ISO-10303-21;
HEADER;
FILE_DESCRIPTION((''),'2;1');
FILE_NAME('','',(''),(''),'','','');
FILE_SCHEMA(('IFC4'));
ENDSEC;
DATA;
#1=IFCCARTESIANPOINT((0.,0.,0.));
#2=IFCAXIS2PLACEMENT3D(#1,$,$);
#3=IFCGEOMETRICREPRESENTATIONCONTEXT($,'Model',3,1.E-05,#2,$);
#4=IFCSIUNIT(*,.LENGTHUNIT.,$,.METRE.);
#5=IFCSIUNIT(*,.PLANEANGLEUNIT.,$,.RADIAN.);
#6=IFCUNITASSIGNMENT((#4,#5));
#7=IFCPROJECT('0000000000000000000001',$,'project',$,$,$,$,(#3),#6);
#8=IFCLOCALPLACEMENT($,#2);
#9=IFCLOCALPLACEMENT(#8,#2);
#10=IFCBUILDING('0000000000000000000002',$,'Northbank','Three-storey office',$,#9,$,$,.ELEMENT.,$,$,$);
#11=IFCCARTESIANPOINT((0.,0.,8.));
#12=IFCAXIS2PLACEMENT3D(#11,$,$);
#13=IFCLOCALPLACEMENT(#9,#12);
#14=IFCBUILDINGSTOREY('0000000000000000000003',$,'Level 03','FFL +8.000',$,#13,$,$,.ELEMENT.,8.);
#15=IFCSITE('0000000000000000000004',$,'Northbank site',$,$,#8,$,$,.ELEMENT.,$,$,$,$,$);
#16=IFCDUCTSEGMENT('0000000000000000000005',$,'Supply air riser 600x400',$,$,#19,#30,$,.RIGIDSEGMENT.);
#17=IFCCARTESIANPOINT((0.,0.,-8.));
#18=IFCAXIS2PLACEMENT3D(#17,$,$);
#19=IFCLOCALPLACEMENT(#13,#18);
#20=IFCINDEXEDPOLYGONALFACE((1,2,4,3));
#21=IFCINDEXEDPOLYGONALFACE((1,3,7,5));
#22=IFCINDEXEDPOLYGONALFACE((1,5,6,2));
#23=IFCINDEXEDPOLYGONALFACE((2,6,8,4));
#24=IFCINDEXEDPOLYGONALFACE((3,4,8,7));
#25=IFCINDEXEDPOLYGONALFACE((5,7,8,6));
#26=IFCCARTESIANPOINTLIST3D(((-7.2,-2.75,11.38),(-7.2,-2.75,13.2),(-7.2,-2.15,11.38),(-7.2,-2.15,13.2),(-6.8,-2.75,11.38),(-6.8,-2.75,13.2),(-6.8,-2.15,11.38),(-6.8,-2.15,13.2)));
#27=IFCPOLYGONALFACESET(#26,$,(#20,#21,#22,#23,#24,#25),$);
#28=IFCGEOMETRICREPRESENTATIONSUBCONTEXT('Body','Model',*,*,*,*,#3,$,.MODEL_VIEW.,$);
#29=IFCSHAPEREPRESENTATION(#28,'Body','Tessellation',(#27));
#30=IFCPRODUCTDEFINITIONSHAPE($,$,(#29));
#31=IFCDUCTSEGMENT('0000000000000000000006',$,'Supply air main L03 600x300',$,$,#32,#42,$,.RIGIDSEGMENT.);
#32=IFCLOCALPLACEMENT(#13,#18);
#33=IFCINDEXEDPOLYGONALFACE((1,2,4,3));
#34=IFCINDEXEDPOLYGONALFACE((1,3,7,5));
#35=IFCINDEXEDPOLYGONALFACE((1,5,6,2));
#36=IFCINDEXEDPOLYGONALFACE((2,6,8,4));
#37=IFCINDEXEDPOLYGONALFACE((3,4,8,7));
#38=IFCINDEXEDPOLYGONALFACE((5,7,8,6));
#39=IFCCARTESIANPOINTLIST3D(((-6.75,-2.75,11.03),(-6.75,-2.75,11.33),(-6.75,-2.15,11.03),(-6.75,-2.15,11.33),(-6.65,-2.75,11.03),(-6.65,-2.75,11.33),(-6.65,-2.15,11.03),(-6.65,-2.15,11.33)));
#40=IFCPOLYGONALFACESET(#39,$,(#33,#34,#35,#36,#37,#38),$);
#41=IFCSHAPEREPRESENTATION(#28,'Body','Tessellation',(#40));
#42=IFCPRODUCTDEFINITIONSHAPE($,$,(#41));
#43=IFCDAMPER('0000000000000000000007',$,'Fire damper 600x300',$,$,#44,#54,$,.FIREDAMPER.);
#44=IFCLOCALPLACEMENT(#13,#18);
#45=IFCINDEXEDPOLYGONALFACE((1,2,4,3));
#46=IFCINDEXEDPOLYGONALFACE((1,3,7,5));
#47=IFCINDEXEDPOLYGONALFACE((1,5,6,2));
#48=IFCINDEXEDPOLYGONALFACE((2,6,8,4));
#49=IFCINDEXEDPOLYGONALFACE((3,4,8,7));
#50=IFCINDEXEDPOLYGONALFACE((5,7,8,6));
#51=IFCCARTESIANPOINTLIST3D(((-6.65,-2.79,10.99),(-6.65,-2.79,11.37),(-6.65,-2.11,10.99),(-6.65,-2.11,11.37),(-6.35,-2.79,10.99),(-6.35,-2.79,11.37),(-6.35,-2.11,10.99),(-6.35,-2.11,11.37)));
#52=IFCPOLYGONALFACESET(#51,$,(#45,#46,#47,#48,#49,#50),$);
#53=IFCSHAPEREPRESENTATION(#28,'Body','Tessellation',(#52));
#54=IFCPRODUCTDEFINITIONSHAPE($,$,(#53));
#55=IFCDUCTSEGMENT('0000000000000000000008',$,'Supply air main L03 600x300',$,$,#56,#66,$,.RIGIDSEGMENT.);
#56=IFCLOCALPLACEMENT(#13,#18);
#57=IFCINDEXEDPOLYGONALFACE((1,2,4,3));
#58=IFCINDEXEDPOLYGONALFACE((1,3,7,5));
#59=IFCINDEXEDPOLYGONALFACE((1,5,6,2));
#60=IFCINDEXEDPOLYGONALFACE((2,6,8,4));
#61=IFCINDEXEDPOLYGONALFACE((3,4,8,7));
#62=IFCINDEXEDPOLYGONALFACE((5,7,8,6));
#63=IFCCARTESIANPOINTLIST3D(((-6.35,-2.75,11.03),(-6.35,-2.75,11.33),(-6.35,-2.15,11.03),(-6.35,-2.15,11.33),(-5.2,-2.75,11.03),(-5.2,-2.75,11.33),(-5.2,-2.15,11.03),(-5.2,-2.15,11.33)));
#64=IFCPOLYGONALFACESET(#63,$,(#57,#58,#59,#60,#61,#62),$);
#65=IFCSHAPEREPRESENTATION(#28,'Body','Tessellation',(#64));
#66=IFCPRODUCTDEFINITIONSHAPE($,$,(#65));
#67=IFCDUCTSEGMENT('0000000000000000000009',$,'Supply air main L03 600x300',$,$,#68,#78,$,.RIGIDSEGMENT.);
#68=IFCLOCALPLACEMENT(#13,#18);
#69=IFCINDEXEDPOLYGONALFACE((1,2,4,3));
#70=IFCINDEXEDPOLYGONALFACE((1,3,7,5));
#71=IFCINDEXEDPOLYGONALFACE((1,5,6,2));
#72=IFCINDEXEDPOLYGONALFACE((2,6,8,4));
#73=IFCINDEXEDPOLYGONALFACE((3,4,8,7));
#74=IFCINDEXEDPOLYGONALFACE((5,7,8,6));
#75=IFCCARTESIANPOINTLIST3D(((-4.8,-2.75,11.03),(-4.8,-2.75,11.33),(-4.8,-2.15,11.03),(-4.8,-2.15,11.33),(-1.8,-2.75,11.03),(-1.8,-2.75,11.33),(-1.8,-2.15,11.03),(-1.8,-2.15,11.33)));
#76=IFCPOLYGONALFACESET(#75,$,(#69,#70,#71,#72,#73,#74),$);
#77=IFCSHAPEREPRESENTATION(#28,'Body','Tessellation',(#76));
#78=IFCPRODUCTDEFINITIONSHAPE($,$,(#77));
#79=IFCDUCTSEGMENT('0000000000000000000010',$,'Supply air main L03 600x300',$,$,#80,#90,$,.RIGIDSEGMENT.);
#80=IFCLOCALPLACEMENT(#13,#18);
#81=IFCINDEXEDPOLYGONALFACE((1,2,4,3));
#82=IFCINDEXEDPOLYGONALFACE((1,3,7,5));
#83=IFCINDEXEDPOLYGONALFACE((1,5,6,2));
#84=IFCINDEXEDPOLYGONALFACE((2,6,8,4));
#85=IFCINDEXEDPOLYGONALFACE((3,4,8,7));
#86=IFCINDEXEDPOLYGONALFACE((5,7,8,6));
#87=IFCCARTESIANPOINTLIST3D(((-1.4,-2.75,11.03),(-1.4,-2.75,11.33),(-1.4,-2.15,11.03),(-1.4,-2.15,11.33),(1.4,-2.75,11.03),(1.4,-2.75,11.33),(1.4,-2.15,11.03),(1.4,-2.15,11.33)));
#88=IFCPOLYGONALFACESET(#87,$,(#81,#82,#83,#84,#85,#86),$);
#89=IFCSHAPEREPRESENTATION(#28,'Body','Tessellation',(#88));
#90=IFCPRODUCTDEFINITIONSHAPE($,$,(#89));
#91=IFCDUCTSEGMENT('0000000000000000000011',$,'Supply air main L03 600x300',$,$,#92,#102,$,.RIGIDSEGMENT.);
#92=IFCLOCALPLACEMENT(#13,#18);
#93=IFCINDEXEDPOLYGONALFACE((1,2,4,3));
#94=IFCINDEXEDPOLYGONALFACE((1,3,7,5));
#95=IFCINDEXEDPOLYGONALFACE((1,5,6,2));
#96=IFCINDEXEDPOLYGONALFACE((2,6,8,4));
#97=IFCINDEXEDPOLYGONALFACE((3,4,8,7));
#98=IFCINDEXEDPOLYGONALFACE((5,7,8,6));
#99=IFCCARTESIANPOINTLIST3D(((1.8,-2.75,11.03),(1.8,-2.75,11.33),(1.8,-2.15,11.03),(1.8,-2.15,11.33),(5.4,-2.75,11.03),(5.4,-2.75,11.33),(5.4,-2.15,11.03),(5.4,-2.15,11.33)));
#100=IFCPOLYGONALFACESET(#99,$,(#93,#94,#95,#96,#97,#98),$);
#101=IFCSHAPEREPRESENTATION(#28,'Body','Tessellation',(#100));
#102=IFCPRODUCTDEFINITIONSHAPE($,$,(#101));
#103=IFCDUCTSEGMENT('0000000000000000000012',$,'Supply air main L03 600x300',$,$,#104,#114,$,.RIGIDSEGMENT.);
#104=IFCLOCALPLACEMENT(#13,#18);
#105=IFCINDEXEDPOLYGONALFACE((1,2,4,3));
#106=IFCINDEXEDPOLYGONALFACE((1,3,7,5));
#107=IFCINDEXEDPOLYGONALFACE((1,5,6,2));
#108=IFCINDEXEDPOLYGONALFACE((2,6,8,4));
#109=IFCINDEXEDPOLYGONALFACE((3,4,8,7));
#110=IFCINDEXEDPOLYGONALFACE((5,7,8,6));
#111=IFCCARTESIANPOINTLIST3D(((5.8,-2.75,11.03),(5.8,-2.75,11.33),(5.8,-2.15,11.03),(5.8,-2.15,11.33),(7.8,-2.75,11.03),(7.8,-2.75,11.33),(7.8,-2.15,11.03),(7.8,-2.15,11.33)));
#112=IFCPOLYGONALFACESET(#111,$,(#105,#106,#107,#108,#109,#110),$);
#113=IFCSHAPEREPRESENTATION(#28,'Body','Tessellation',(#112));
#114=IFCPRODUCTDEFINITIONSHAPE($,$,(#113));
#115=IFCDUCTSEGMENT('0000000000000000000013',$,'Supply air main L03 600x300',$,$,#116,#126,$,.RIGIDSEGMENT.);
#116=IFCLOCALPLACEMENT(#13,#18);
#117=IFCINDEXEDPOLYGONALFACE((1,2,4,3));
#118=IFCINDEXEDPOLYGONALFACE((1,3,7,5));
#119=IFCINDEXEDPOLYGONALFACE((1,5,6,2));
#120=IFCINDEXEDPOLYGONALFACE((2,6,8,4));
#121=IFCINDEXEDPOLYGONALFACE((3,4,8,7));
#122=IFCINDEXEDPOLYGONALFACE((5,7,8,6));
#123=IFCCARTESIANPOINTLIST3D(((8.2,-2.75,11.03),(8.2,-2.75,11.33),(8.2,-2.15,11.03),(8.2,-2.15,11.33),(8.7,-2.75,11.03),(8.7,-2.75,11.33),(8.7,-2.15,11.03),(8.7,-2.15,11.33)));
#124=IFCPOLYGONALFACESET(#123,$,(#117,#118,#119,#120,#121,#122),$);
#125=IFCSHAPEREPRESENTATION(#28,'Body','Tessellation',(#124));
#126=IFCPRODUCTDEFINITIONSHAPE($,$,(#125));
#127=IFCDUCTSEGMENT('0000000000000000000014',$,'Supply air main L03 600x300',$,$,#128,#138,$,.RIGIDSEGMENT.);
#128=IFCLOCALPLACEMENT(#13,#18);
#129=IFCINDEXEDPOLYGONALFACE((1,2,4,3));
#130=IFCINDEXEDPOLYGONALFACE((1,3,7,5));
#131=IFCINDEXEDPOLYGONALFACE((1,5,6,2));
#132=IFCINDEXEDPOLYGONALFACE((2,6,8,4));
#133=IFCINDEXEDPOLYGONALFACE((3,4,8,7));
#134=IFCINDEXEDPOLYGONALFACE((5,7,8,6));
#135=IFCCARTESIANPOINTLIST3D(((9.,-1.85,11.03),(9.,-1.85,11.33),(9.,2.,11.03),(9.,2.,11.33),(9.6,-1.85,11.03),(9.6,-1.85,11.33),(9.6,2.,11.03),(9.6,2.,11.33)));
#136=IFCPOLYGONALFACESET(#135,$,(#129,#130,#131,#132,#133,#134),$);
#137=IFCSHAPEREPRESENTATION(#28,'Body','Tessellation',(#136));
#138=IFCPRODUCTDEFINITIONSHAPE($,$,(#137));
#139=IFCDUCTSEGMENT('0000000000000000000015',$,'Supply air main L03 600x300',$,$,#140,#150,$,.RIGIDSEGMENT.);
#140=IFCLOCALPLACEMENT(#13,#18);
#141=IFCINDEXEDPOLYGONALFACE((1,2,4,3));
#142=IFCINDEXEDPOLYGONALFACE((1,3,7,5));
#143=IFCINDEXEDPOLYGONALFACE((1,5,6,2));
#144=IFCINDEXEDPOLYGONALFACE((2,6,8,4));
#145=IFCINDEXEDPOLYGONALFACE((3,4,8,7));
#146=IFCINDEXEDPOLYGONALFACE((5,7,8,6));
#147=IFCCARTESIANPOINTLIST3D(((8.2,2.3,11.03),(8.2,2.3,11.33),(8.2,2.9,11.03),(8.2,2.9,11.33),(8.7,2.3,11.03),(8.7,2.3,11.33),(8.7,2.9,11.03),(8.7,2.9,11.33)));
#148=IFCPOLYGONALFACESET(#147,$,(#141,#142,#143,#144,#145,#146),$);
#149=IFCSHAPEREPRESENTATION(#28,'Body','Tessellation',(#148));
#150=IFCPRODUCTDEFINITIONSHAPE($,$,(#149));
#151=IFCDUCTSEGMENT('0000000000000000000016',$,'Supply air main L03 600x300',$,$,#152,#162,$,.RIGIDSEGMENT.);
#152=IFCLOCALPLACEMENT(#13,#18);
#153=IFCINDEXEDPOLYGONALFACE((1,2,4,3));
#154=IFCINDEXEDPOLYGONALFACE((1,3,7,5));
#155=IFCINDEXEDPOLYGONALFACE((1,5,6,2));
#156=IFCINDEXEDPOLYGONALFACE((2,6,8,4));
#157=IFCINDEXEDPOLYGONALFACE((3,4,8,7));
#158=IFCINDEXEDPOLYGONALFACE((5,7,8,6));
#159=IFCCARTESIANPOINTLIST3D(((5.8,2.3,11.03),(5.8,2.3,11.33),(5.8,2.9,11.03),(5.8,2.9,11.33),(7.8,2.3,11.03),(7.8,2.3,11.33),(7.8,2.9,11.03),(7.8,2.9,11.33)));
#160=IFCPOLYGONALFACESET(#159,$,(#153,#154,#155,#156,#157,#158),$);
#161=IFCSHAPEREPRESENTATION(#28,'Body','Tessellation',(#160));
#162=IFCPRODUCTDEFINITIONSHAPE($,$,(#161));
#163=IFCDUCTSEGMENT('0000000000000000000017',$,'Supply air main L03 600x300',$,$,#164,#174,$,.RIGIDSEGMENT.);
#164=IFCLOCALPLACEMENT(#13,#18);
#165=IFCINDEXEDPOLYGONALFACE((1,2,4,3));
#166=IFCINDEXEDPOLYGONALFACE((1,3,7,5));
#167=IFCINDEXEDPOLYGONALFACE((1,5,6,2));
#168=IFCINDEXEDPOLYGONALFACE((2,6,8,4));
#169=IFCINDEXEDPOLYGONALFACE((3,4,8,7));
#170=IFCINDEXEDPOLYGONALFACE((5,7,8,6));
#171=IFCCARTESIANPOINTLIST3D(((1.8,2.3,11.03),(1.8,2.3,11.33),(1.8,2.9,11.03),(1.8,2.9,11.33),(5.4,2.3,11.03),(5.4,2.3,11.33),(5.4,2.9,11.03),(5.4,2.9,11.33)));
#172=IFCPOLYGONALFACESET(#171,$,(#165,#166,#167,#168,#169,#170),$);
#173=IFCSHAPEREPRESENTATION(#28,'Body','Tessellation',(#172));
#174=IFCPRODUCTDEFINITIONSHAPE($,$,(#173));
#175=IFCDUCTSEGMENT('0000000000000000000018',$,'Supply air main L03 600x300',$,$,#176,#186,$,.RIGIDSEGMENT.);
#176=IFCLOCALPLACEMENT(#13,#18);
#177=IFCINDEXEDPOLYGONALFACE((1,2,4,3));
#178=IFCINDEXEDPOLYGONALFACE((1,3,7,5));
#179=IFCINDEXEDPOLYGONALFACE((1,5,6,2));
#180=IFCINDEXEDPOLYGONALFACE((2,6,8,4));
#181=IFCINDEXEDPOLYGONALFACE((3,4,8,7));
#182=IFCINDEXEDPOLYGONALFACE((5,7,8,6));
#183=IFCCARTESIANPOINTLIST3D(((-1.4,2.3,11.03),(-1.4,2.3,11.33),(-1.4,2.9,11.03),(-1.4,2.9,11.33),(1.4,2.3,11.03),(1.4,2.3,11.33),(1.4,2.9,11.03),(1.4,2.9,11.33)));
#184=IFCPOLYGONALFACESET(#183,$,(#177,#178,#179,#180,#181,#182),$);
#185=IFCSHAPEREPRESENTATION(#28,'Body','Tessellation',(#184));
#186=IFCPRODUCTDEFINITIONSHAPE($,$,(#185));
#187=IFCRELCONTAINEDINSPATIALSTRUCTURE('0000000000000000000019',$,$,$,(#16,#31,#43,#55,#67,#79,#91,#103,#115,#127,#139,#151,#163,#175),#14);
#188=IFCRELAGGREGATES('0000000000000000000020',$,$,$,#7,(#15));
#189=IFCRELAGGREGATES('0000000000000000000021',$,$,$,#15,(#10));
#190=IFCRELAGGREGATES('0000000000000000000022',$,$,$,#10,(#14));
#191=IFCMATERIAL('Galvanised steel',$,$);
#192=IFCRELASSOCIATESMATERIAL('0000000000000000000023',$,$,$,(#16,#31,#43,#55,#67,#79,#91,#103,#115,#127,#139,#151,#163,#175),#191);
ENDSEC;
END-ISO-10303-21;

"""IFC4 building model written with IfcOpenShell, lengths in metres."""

from ifc_helpers import new_model, si_unit, frame, origin, place, context, subcontext, project, spatial, rectangle, extrude, material, element, save


model = new_model("IFC4")

# Units and contexts
model_context = context("Model", 3, precision=1e-05, world=origin())
body_context = subcontext(model_context, "Body", "Model", "MODEL_VIEW")
ifc_project = project(units=[si_unit("LENGTHUNIT", "METRE"), si_unit("PLANEANGLEUNIT", "RADIAN")], contexts=[model_context])

# Site, building, storey
site_placement = place(None, origin())
site = spatial("IfcSite", under=ifc_project, at=site_placement, Name="Northbank site", CompositionType="ELEMENT")
building_placement = place(site_placement, origin())
building = spatial("IfcBuilding", under=site, at=building_placement, Name="Northbank", Description="Three-storey office", CompositionType="ELEMENT")
storey_placement = place(building_placement, frame((0.0, 0.0, 8.0)))
storey = spatial("IfcBuildingStorey", under=building, at=storey_placement, Name="Level 03", Description="FFL +8.000", CompositionType="ELEMENT", Elevation=8.0)

# Shared definitions
ifc_material_1 = material(Name="Galvanised steel")

# Duct segments
duct_segment_1_placement = place(storey_placement, frame((0.0, 0.0, -8.0)))
element("IfcDuctSegment", 1, at=duct_segment_1_placement, inside=storey, material=ifc_material_1, Name="Supply air riser 600x400", PredefinedType="RIGIDSEGMENT", context=body_context, shape_type="SweptSolid", body=[
    extrude(rectangle(XDim=0.6, YDim=0.4), frame((-7.0, -2.45, 13.2), z_axis=(0.0, 0.0, -1.0), x_axis=(0.0, -1.0, 0.0)), (0.0, 0.0, 1.0), 1.82),
])
duct_segment_2_placement = place(storey_placement, frame((0.0, 0.0, -8.0)))
element("IfcDuctSegment", 2, at=duct_segment_2_placement, inside=storey, material=ifc_material_1, Name="Supply air main L03 600x300", PredefinedType="RIGIDSEGMENT", context=body_context, shape_type="SweptSolid", body=[
    extrude(rectangle(XDim=0.6, YDim=0.3), frame((-6.75, -2.45, 11.18), z_axis=(1.0, 0.0, 0.0), x_axis=(0.0, 1.0, 0.0)), (0.0, 0.0, 1.0), 0.1),
])

# Damper
damper_placement = place(storey_placement, frame((0.0, 0.0, -8.0)))
element("IfcDamper", 3, at=damper_placement, inside=storey, material=ifc_material_1, Name="Fire damper 600x300", PredefinedType="FIREDAMPER", context=body_context, shape_type="SweptSolid", body=[
    extrude(rectangle(XDim=0.68, YDim=0.38), frame((-6.65, -2.45, 11.18), z_axis=(1.0, 0.0, 0.0), x_axis=(0.0, 1.0, 0.0)), (0.0, 0.0, 1.0), 0.3),
])

# Duct segment
duct_segment_3_placement = place(storey_placement, frame((0.0, 0.0, -8.0)))
element("IfcDuctSegment", 4, at=duct_segment_3_placement, inside=storey, material=ifc_material_1, Name="Supply air main L03 600x300", PredefinedType="RIGIDSEGMENT", context=body_context, shape_type="SweptSolid", body=[
    extrude(rectangle(XDim=0.6, YDim=0.3), frame((-6.35, -2.45, 11.18), z_axis=(1.0, 0.0, 0.0), x_axis=(0.0, 1.0, 0.0)), (0.0, 0.0, 1.0), 1.15),
])

# Duct segment
duct_segment_4_placement = place(storey_placement, frame((0.0, 0.0, -8.0)))
element("IfcDuctSegment", 5, at=duct_segment_4_placement, inside=storey, material=ifc_material_1, Name="Supply air main L03 600x300", PredefinedType="RIGIDSEGMENT", context=body_context, shape_type="SweptSolid", body=[
    extrude(rectangle(XDim=0.6, YDim=0.3), frame((-4.8, -2.45, 11.18), z_axis=(1.0, 0.0, 0.0), x_axis=(0.0, 1.0, 0.0)), (0.0, 0.0, 1.0), 3.0),
])

# Duct segment
duct_segment_5_placement = place(storey_placement, frame((0.0, 0.0, -8.0)))
element("IfcDuctSegment", 6, at=duct_segment_5_placement, inside=storey, material=ifc_material_1, Name="Supply air main L03 600x300", PredefinedType="RIGIDSEGMENT", context=body_context, shape_type="SweptSolid", body=[
    extrude(rectangle(XDim=0.6, YDim=0.3), frame((-1.4, -2.45, 11.18), z_axis=(1.0, 0.0, 0.0), x_axis=(0.0, 1.0, 0.0)), (0.0, 0.0, 1.0), 2.8),
])

# Duct segment
duct_segment_6_placement = place(storey_placement, frame((0.0, 0.0, -8.0)))
element("IfcDuctSegment", 7, at=duct_segment_6_placement, inside=storey, material=ifc_material_1, Name="Supply air main L03 600x300", PredefinedType="RIGIDSEGMENT", context=body_context, shape_type="SweptSolid", body=[
    extrude(rectangle(XDim=0.6, YDim=0.3), frame((1.8, -2.45, 11.18), z_axis=(1.0, 0.0, 0.0), x_axis=(0.0, 1.0, 0.0)), (0.0, 0.0, 1.0), 3.6),
])

# Duct segments
duct_segment_7_placement = place(storey_placement, frame((0.0, 0.0, -8.0)))
element("IfcDuctSegment", 8, at=duct_segment_7_placement, inside=storey, material=ifc_material_1, Name="Supply air main L03 600x300", PredefinedType="RIGIDSEGMENT", context=body_context, shape_type="SweptSolid", body=[
    extrude(rectangle(XDim=0.6, YDim=0.3), frame((5.8, -2.45, 11.18), z_axis=(1.0, 0.0, 0.0), x_axis=(0.0, 1.0, 0.0)), (0.0, 0.0, 1.0), 2.0),
])
duct_segment_8_placement = place(storey_placement, frame((0.0, 0.0, -8.0)))
element("IfcDuctSegment", 9, at=duct_segment_8_placement, inside=storey, material=ifc_material_1, Name="Supply air main L03 600x300", PredefinedType="RIGIDSEGMENT", context=body_context, shape_type="SweptSolid", body=[
    extrude(rectangle(XDim=0.6, YDim=0.3), frame((8.2, -2.45, 11.18), z_axis=(1.0, 0.0, 0.0), x_axis=(0.0, 1.0, 0.0)), (0.0, 0.0, 1.0), 0.5),
])
duct_segment_9_placement = place(storey_placement, frame((0.0, 0.0, -8.0)))
element("IfcDuctSegment", 10, at=duct_segment_9_placement, inside=storey, material=ifc_material_1, Name="Supply air main L03 600x300", PredefinedType="RIGIDSEGMENT", context=body_context, shape_type="SweptSolid", body=[
    extrude(rectangle(XDim=0.6, YDim=0.3), frame((9.3, -1.85, 11.18), z_axis=(0.0, 1.0, 0.0), x_axis=(-1.0, 0.0, 0.0)), (0.0, 0.0, 1.0), 3.85),
])

# Duct segment
duct_segment_10_placement = place(storey_placement, frame((0.0, 0.0, -8.0)))
element("IfcDuctSegment", 11, at=duct_segment_10_placement, inside=storey, material=ifc_material_1, Name="Supply air main L03 600x300", PredefinedType="RIGIDSEGMENT", context=body_context, shape_type="SweptSolid", body=[
    extrude(rectangle(XDim=0.6, YDim=0.3), frame((8.7, 2.6, 11.18), z_axis=(-1.0, 0.0, 0.0), x_axis=(0.0, -1.0, 0.0)), (0.0, 0.0, 1.0), 0.5),
])

# Duct segment
duct_segment_11_placement = place(storey_placement, frame((0.0, 0.0, -8.0)))
element("IfcDuctSegment", 12, at=duct_segment_11_placement, inside=storey, material=ifc_material_1, Name="Supply air main L03 600x300", PredefinedType="RIGIDSEGMENT", context=body_context, shape_type="SweptSolid", body=[
    extrude(rectangle(XDim=0.6, YDim=0.3), frame((7.8, 2.6, 11.18), z_axis=(-1.0, 0.0, 0.0), x_axis=(0.0, -1.0, 0.0)), (0.0, 0.0, 1.0), 2.0),
])

# Duct segment
duct_segment_12_placement = place(storey_placement, frame((0.0, 0.0, -8.0)))
element("IfcDuctSegment", 13, at=duct_segment_12_placement, inside=storey, material=ifc_material_1, Name="Supply air main L03 600x300", PredefinedType="RIGIDSEGMENT", context=body_context, shape_type="SweptSolid", body=[
    extrude(rectangle(XDim=0.6, YDim=0.3), frame((5.4, 2.6, 11.18), z_axis=(-1.0, 0.0, 0.0), x_axis=(0.0, -1.0, 0.0)), (0.0, 0.0, 1.0), 3.6),
])

# Duct segment
duct_segment_13_placement = place(storey_placement, frame((0.0, 0.0, -8.0)))
element("IfcDuctSegment", 14, at=duct_segment_13_placement, inside=storey, material=ifc_material_1, Name="Supply air main L03 600x300", PredefinedType="RIGIDSEGMENT", context=body_context, shape_type="SweptSolid", body=[
    extrude(rectangle(XDim=0.6, YDim=0.3), frame((1.4, 2.6, 11.18), z_axis=(-1.0, 0.0, 0.0), x_axis=(0.0, -1.0, 0.0)), (0.0, 0.0, 1.0), 2.8),
])

save(model, "model.ifc")
